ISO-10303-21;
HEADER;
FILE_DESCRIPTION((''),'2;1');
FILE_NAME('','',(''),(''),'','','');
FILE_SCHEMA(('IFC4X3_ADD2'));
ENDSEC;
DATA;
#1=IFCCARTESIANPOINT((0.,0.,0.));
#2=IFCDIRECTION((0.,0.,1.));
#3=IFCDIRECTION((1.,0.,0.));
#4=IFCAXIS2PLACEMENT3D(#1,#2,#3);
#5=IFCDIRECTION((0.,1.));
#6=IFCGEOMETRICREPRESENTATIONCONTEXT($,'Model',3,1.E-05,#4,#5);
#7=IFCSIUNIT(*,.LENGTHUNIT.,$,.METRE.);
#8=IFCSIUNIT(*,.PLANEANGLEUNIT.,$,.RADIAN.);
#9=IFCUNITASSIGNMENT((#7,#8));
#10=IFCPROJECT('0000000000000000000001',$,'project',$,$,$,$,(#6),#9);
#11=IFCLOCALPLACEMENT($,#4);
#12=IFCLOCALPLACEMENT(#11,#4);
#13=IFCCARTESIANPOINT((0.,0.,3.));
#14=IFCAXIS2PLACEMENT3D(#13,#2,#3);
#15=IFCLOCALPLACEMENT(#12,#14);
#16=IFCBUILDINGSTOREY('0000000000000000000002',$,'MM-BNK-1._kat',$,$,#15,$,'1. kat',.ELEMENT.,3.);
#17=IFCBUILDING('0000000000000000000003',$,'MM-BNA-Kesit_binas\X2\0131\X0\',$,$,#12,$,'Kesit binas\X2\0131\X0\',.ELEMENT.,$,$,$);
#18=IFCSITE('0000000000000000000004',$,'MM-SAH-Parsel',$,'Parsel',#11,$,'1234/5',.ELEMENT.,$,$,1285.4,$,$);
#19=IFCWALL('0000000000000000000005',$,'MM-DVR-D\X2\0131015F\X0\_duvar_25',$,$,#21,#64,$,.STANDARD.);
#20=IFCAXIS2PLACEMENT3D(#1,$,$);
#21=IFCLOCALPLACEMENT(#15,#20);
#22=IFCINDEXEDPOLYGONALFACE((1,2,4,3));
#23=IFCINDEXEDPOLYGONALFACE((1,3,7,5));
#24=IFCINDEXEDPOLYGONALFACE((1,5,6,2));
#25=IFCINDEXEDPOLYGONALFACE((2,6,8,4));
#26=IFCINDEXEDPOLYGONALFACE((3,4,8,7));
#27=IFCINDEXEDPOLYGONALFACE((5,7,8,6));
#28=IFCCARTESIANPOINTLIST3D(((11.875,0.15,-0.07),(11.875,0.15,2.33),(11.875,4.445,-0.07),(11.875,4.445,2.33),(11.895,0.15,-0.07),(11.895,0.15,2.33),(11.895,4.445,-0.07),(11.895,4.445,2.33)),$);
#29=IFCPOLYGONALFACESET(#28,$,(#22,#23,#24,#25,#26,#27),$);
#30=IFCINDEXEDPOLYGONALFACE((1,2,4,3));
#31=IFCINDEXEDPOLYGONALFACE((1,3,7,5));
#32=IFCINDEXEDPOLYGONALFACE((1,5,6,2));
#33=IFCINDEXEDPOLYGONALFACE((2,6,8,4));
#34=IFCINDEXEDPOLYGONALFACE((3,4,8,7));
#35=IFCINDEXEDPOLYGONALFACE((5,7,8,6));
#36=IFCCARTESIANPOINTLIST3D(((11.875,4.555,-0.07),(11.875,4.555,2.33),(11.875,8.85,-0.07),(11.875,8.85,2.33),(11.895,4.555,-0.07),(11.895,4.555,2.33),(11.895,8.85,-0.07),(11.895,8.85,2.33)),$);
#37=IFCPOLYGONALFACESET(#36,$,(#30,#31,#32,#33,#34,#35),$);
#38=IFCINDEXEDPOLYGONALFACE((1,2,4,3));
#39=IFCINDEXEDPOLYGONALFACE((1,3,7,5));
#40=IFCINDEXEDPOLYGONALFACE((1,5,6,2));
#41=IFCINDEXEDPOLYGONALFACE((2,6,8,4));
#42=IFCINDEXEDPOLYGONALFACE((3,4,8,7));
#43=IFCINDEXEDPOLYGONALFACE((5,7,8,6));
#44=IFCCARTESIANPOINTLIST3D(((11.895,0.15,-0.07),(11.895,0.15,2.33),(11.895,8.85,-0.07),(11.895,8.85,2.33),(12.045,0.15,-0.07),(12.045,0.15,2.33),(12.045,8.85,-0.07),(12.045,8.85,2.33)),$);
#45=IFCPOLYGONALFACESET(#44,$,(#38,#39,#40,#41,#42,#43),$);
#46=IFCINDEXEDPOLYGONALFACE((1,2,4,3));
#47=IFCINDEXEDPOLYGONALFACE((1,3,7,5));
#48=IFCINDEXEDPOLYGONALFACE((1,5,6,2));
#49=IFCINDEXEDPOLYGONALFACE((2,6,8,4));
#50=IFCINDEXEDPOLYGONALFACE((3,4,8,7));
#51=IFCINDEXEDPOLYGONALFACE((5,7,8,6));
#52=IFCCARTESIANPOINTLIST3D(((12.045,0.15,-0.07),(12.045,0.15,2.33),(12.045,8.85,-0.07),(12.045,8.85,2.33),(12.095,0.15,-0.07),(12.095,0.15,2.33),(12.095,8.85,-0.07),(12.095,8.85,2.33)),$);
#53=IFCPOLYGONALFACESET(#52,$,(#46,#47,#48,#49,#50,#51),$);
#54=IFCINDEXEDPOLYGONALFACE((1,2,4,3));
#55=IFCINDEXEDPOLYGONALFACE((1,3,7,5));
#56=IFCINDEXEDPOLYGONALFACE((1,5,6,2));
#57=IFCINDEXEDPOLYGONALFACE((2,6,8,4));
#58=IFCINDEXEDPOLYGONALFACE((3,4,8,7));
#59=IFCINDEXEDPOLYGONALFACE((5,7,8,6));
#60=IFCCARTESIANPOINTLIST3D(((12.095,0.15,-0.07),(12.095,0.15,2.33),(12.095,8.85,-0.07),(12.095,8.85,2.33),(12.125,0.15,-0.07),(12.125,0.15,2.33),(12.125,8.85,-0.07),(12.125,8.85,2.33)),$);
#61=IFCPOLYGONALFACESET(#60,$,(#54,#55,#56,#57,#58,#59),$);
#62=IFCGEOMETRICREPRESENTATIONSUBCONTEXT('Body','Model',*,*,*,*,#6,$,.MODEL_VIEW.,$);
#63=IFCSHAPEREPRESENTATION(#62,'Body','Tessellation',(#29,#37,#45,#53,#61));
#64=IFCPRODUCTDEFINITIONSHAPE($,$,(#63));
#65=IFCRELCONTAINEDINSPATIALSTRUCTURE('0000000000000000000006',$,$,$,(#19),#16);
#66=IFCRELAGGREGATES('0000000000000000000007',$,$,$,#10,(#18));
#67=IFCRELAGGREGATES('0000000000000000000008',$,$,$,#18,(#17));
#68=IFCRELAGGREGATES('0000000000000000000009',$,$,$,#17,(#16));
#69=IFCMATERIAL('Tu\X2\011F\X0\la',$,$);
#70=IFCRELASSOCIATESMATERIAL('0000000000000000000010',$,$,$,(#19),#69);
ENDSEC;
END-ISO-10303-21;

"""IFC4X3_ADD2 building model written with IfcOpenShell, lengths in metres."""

from ifc_helpers import new_model, si_unit, direction, frame, origin_with_axes, place, context, subcontext, project, spatial, polyline, outline, extrude, material, element, save


model = new_model("IFC4X3_ADD2")

# Units and contexts
model_context = context("Model", 3, precision=1e-05, world=origin_with_axes(), true_north=direction((0.0, 1.0)))
body_context = subcontext(model_context, "Body", "Model", "MODEL_VIEW")
ifc_project = project(units=[si_unit("LENGTHUNIT", "METRE"), si_unit("PLANEANGLEUNIT", "RADIAN")], contexts=[model_context])

# Site, building, storey
site_placement = place(None, origin_with_axes())
site = spatial("IfcSite", under=ifc_project, at=site_placement, Name="MM-SAH-Parsel", ObjectType="Parsel", LongName="1234/5", CompositionType="ELEMENT", RefElevation=1285.4)
building_placement = place(site_placement, origin_with_axes())
building = spatial("IfcBuilding", under=site, at=building_placement, Name="MM-BNA-Kesit_binası", LongName="Kesit binası", CompositionType="ELEMENT")
storey_placement = place(building_placement, frame((0.0, 0.0, 3.0), z_axis=(0.0, 0.0, 1.0), x_axis=(1.0, 0.0, 0.0)))
storey = spatial("IfcBuildingStorey", under=building, at=storey_placement, Name="MM-BNK-1._kat", LongName="1. kat", CompositionType="ELEMENT", Elevation=3.0)

# Shared definitions
ifc_material_1 = material(Name="Tuğla")

# Wall
wall_1_placement = place(storey_placement, origin_with_axes())
element("IfcWall", 1, at=wall_1_placement, inside=storey, material=ifc_material_1, Name="MM-DVR-Dış_duvar_25", PredefinedType="STANDARD", context=body_context, shape_type="SweptSolid", body=[
    extrude(outline(polyline([(11.895, 0.15), (11.895, 4.445), (11.875, 4.445), (11.875, 0.15), (11.895, 0.15)])), frame((0.0, 0.0, -0.07)), (0.0, 0.0, 1.0), 2.4),
    extrude(outline(polyline([(11.895, 4.555), (11.895, 8.85), (11.875, 8.85), (11.875, 4.555), (11.895, 4.555)])), frame((0.0, 0.0, -0.07)), (0.0, 0.0, 1.0), 2.4),
    extrude(outline(polyline([(12.045, 0.15), (12.045, 8.85), (11.895, 8.85), (11.895, 0.15), (12.045, 0.15)])), frame((0.0, 0.0, -0.07)), (0.0, 0.0, 1.0), 2.4),
    extrude(outline(polyline([(12.095, 0.15), (12.095, 8.85), (12.045, 8.85), (12.045, 0.15), (12.095, 0.15)])), frame((0.0, 0.0, -0.07)), (0.0, 0.0, 1.0), 2.4),
    extrude(outline(polyline([(12.125, 0.15), (12.125, 8.85), (12.095, 8.85), (12.095, 0.15), (12.125, 0.15)])), frame((0.0, 0.0, -0.07)), (0.0, 0.0, 1.0), 2.4),
])

save(model, "model.ifc")
